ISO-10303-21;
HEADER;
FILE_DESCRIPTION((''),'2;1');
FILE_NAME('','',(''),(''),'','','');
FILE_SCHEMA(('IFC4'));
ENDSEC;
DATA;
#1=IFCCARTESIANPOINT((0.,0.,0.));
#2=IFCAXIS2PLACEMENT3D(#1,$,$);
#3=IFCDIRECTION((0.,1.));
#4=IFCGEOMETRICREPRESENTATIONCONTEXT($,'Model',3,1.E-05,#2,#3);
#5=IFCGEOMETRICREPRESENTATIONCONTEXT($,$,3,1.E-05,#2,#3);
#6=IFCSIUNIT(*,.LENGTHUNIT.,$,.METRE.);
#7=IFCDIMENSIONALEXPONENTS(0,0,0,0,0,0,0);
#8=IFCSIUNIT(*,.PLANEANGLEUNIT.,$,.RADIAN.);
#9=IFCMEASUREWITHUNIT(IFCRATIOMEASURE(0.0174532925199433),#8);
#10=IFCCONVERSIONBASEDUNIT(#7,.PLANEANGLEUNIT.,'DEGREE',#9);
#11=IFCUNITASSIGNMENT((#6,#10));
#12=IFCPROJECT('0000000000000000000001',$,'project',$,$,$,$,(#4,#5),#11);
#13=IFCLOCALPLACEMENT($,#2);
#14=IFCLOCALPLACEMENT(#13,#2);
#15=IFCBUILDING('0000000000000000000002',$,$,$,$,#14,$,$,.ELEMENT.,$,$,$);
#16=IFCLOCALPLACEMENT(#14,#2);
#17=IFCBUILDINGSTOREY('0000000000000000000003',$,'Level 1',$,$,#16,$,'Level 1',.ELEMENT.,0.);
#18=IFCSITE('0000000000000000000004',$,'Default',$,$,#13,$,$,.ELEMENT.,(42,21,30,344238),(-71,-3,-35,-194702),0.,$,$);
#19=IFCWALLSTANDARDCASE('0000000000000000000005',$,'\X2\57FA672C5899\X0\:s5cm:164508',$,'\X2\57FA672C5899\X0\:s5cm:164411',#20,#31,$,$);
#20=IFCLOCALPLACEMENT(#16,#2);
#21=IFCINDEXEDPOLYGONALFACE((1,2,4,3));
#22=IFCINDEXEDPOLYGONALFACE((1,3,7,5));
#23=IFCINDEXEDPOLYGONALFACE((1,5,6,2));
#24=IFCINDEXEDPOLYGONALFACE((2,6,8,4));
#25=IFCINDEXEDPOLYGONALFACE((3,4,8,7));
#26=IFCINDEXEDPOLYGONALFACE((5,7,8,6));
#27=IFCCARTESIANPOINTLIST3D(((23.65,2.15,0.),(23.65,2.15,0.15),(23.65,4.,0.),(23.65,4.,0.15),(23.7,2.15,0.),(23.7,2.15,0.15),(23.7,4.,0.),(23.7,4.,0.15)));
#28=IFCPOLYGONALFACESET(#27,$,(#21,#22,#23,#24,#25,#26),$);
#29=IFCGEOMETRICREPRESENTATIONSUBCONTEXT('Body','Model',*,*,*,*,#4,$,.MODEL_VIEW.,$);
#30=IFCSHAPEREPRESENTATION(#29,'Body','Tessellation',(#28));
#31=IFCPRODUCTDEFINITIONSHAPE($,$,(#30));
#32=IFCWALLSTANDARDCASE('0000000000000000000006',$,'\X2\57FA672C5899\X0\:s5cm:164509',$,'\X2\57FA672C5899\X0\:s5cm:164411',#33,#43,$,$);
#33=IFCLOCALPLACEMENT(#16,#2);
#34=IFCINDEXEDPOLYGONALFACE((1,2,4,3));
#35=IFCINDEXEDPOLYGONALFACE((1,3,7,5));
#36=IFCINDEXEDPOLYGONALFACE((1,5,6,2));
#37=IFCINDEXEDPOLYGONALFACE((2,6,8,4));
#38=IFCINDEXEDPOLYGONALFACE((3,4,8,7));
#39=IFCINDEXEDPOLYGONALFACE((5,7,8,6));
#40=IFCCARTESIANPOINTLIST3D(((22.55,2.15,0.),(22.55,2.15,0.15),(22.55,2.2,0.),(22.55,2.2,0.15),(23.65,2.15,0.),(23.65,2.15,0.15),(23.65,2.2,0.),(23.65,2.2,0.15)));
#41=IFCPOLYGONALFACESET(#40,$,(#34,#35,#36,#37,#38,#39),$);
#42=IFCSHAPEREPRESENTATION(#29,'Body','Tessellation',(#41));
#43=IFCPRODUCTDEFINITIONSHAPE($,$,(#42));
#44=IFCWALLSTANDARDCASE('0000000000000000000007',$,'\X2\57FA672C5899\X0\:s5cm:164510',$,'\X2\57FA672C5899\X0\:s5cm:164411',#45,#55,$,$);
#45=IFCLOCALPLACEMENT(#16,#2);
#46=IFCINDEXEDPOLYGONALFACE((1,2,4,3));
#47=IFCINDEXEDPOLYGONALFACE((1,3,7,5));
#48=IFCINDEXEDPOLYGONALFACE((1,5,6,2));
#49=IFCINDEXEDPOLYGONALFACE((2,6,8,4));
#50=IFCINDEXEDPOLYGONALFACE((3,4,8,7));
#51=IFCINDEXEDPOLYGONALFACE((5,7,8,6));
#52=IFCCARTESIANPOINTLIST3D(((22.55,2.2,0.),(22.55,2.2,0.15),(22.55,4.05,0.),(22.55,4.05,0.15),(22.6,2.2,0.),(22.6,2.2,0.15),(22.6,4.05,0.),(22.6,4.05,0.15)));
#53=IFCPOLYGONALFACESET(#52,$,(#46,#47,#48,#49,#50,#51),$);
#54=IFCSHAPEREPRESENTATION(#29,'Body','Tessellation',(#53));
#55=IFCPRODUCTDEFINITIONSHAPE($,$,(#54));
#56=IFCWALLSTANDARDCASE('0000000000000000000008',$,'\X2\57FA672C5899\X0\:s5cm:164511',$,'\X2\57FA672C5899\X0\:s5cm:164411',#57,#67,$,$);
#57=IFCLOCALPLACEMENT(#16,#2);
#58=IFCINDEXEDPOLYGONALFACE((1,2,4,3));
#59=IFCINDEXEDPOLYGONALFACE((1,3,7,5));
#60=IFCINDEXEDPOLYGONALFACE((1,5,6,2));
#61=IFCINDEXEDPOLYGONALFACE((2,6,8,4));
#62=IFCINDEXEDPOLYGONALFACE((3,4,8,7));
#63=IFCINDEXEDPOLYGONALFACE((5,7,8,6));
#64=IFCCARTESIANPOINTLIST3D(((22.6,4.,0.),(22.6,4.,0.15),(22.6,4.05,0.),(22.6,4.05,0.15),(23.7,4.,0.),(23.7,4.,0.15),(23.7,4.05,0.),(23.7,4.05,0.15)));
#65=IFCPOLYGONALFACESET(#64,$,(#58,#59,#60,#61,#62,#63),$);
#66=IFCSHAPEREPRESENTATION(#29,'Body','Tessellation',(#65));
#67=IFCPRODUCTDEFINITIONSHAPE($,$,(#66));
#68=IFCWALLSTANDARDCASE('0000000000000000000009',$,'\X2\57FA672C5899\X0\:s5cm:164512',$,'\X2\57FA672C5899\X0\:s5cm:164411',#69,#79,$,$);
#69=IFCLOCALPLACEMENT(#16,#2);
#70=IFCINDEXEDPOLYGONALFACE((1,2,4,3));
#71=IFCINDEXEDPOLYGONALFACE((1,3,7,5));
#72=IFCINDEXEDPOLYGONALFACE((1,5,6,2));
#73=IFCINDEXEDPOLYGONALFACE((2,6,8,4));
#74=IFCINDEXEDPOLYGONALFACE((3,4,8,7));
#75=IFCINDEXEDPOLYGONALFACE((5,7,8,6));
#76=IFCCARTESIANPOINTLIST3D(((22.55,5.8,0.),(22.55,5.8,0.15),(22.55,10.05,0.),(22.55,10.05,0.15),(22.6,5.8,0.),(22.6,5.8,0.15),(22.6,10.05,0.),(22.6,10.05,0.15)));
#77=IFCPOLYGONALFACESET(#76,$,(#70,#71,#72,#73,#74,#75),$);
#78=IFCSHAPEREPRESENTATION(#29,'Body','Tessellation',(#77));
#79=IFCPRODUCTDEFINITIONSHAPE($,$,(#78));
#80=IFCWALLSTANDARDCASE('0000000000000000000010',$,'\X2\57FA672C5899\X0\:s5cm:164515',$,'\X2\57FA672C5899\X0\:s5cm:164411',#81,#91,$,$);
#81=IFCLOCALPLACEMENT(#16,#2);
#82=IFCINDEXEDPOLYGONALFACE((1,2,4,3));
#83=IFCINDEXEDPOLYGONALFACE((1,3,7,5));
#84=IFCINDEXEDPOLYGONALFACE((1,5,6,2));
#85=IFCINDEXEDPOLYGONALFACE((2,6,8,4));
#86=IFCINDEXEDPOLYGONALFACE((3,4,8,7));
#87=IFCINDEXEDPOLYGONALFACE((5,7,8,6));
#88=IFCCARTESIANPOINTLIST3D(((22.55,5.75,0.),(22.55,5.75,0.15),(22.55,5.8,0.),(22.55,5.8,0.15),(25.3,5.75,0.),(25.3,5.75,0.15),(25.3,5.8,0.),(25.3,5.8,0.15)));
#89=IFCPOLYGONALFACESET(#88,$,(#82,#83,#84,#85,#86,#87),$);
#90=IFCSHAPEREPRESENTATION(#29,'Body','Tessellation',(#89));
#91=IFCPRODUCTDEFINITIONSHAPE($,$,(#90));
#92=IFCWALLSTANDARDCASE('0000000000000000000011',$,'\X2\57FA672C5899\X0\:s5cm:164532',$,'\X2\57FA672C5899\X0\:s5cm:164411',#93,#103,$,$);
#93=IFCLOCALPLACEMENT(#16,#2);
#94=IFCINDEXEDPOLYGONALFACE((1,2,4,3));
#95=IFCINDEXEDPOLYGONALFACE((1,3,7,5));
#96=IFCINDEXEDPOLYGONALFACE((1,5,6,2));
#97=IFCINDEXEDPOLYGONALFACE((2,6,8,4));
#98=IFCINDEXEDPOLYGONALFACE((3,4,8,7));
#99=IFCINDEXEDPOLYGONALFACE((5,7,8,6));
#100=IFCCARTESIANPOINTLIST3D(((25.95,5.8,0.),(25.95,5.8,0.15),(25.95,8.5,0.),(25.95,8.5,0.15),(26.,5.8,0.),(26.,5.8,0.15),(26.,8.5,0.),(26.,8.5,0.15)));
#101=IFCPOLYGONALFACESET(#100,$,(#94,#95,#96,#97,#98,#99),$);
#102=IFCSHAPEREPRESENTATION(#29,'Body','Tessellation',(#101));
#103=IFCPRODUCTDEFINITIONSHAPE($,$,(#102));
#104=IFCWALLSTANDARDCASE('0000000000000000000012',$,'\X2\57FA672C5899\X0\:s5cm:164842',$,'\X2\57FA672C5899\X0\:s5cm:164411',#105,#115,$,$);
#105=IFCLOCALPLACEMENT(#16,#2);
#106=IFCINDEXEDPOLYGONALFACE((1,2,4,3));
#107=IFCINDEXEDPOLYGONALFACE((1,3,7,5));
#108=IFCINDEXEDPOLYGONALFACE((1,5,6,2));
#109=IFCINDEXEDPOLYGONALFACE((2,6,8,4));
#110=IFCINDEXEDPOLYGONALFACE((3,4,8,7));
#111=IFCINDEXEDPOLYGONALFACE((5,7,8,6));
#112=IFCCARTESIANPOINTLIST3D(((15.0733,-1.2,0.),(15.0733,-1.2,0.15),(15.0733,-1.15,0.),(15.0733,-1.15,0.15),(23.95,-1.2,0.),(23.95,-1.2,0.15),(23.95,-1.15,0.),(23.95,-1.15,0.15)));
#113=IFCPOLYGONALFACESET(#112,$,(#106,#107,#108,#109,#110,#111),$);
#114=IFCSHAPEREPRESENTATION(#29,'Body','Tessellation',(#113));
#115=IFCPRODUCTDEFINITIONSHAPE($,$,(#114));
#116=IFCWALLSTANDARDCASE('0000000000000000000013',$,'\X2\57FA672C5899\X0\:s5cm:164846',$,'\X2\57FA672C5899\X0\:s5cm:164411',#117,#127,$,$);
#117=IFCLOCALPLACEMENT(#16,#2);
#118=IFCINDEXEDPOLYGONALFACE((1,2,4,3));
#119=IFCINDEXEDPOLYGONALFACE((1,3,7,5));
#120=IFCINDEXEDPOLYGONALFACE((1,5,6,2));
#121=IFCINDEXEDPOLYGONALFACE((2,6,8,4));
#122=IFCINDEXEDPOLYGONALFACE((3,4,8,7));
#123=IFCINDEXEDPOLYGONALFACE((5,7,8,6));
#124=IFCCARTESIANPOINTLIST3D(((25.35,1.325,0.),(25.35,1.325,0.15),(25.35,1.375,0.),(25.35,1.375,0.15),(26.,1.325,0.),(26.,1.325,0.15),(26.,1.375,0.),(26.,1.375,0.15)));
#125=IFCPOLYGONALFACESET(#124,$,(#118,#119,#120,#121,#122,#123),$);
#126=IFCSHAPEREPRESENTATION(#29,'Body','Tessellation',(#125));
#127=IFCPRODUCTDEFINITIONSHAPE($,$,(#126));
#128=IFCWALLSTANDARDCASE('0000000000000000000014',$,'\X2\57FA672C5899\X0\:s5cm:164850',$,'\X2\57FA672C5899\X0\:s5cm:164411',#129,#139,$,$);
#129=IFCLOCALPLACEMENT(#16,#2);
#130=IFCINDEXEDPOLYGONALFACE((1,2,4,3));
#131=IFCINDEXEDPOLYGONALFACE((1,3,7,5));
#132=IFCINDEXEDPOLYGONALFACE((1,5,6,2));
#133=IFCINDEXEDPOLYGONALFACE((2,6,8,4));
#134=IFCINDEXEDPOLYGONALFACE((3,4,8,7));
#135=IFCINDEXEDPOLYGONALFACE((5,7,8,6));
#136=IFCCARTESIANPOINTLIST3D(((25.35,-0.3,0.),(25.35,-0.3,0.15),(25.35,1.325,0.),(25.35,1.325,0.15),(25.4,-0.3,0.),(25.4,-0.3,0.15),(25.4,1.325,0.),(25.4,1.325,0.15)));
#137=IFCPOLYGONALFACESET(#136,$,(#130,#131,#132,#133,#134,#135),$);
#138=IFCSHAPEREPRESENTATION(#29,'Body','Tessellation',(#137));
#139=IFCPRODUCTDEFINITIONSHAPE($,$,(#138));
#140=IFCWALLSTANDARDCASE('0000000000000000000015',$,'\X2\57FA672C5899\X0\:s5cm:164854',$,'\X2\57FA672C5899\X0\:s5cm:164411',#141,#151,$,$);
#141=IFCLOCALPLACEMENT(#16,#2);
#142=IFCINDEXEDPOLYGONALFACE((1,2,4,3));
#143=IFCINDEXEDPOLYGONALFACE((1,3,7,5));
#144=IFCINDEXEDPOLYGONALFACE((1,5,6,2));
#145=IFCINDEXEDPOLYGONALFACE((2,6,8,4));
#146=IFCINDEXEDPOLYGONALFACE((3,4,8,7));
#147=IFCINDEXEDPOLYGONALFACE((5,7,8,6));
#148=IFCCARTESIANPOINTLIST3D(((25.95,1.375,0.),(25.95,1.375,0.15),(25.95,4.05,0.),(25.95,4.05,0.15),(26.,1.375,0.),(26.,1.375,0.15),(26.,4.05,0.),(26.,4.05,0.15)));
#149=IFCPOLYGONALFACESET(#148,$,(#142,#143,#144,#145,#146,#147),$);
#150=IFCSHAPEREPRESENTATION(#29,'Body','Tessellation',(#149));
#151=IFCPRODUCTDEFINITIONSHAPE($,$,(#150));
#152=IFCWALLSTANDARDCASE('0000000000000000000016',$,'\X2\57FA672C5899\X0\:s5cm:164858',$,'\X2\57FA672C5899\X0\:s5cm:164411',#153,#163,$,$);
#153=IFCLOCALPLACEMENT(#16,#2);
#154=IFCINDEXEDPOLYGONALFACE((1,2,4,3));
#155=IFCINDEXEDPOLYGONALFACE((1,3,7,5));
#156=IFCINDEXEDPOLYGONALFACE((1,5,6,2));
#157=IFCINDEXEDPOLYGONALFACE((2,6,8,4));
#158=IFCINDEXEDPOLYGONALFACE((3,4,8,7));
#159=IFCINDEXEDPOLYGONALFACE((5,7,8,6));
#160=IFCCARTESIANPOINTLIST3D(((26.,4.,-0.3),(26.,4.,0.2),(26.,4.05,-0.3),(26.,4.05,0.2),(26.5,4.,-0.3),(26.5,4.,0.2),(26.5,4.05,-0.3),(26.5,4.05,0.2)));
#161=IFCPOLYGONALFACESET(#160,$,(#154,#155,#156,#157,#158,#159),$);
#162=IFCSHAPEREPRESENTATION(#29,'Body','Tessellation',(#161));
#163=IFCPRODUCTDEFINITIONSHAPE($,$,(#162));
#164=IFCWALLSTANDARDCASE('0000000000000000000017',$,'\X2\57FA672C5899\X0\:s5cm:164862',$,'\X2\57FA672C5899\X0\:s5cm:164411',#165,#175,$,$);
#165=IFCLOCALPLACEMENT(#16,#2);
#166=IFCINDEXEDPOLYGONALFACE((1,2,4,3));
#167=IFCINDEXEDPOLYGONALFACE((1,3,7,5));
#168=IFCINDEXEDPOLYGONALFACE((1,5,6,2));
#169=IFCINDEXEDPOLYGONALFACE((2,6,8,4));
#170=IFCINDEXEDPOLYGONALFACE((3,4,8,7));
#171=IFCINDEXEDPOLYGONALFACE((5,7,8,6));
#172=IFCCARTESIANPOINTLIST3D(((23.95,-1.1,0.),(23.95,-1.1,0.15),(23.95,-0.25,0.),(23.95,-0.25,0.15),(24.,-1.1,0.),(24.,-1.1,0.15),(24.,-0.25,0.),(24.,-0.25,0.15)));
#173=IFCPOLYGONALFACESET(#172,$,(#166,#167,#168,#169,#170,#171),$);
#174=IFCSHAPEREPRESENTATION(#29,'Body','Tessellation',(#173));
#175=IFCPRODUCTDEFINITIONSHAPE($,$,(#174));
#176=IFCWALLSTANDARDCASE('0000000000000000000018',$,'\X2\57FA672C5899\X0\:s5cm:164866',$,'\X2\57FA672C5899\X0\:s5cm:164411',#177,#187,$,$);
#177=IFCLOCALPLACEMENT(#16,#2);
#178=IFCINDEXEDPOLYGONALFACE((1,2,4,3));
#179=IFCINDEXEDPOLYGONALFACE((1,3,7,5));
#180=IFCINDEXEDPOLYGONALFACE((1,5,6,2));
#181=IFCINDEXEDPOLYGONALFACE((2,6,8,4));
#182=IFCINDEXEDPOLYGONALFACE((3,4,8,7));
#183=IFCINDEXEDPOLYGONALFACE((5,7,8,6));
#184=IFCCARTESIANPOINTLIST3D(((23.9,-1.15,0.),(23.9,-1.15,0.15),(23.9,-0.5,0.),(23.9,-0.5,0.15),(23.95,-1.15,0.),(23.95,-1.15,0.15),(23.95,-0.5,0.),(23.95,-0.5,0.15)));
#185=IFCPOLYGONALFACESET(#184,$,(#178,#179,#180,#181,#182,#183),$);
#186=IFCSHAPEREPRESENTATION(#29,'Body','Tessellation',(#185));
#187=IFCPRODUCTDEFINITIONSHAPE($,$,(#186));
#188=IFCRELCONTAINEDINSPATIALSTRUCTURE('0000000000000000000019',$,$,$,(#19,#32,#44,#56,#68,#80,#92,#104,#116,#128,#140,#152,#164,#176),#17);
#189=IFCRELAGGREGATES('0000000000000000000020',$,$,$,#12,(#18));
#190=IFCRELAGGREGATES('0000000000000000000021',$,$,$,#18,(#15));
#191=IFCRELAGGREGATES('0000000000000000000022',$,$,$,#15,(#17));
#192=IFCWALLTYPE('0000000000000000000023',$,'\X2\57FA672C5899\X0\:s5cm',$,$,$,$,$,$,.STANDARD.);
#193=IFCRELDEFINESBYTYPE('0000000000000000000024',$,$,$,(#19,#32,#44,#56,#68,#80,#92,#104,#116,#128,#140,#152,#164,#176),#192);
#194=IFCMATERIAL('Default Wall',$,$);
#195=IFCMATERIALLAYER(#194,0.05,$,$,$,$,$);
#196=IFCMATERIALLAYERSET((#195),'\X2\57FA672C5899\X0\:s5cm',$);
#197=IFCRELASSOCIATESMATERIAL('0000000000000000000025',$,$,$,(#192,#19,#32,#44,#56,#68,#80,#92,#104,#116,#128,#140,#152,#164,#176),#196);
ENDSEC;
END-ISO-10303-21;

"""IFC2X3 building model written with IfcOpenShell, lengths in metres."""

from ifc_helpers import new_model, entity, si_unit, converted_unit, direction, frame, frame_2d, origin, place, context, subcontext, project, spatial, rectangle, extrude, material, layer, layer_set, layer_usage, type_object, element, save


model = new_model("IFC2X3")

# Units and contexts
model_context = context("Model", 3, precision=1e-05, world=origin(), true_north=direction((0.0, 1.0)))
context_of_model = context(None, 3, precision=1e-05, world=origin(), true_north=direction((0.0, 1.0)))
body_context = subcontext(model_context, "Body", "Model", "MODEL_VIEW")
ifc_project = project(units=[si_unit("LENGTHUNIT", "METRE"), converted_unit("PLANEANGLEUNIT", "DEGREE", entity("IfcRatioMeasure", 0.0174532925199433), si_unit("PLANEANGLEUNIT", "RADIAN"), dimensions=[0, 0, 0, 0, 0, 0, 0])], contexts=[model_context, context_of_model])

# Site, building, storey
site_placement = place(None, origin())
site = spatial("IfcSite", under=ifc_project, at=site_placement, Name="Default", CompositionType="ELEMENT", RefLatitude=(42, 21, 30, 344238), RefLongitude=(-71, -3, -35, -194702), RefElevation=0.0)
building_placement = place(site_placement, origin())
building = spatial("IfcBuilding", under=site, at=building_placement, CompositionType="ELEMENT")
storey_placement = place(building_placement, origin())
storey = spatial("IfcBuildingStorey", under=building, at=storey_placement, Name="Level 1", LongName="Level 1", CompositionType="ELEMENT", Elevation=0.0)

# Walls
ifc_material = material(Name="Default Wall")
ifc_layer = layer(ifc_material, 0.05)
ifc_layer_set = layer_set([ifc_layer], Name="基本墙:s5cm")
ifc_layer_usage_1 = layer_usage(ifc_layer_set, "AXIS2", "NEGATIVE", 0.025)
wall_type = type_object("IfcWallType", Name="基本墙:s5cm", PredefinedType="STANDARD", material=ifc_layer_set)
wall_1_placement = place(storey_placement, frame((23.675, 4.0, 0.0), z_axis=(0.0, 0.0, 1.0), x_axis=(0.0, -1.0, 0.0)))
element("IfcWallStandardCase", 1, at=wall_1_placement, inside=storey, type_object=wall_type, material=ifc_layer_usage_1, Name="基本墙:s5cm:164508", ObjectType="基本墙:s5cm:164411", context=body_context, shape_type="SweptSolid", body=[
    extrude(rectangle(XDim=1.85, YDim=0.05, at=frame_2d((0.925, 0.0), x_axis=(-1.0, 0.0))), origin(), (0.0, 0.0, 1.0), 0.15),
])
ifc_layer_usage_2 = layer_usage(ifc_layer_set, "AXIS2", "NEGATIVE", 0.025)
wall_2_placement = place(storey_placement, frame((23.65, 2.175, 0.0), z_axis=(0.0, 0.0, 1.0), x_axis=(-1.0, 0.0, 0.0)))
element("IfcWallStandardCase", 2, at=wall_2_placement, inside=storey, type_object=wall_type, material=ifc_layer_usage_2, Name="基本墙:s5cm:164509", ObjectType="基本墙:s5cm:164411", context=body_context, shape_type="SweptSolid", body=[
    extrude(rectangle(XDim=1.1, YDim=0.05, at=frame_2d((0.55, 0.0), x_axis=(-1.0, 0.0))), origin(), (0.0, 0.0, 1.0), 0.15),
])
ifc_layer_usage_3 = layer_usage(ifc_layer_set, "AXIS2", "NEGATIVE", 0.025)
wall_3_placement = place(storey_placement, frame((22.575, 2.2, 0.0), z_axis=(0.0, 0.0, 1.0), x_axis=(0.0, 1.0, 0.0)))
element("IfcWallStandardCase", 3, at=wall_3_placement, inside=storey, type_object=wall_type, material=ifc_layer_usage_3, Name="基本墙:s5cm:164510", ObjectType="基本墙:s5cm:164411", context=body_context, shape_type="SweptSolid", body=[
    extrude(rectangle(XDim=1.85, YDim=0.05, at=frame_2d((0.925, 0.0), x_axis=(-1.0, 0.0))), origin(), (0.0, 0.0, 1.0), 0.15),
])
ifc_layer_usage_4 = layer_usage(ifc_layer_set, "AXIS2", "NEGATIVE", 0.025)
wall_4_placement = place(storey_placement, frame((22.6, 4.025, 0.0)))
element("IfcWallStandardCase", 4, at=wall_4_placement, inside=storey, type_object=wall_type, material=ifc_layer_usage_4, Name="基本墙:s5cm:164511", ObjectType="基本墙:s5cm:164411", context=body_context, shape_type="SweptSolid", body=[
    extrude(rectangle(XDim=1.1, YDim=0.05, at=frame_2d((0.55, 0.0), x_axis=(-1.0, 0.0))), origin(), (0.0, 0.0, 1.0), 0.15),
])
ifc_layer_usage_5 = layer_usage(ifc_layer_set, "AXIS2", "NEGATIVE", 0.025)
wall_5_placement = place(storey_placement, frame((22.575, 5.8, 0.0), z_axis=(0.0, 0.0, 1.0), x_axis=(0.0, 1.0, 0.0)))
element("IfcWallStandardCase", 5, at=wall_5_placement, inside=storey, type_object=wall_type, material=ifc_layer_usage_5, Name="基本墙:s5cm:164512", ObjectType="基本墙:s5cm:164411", context=body_context, shape_type="SweptSolid", body=[
    extrude(rectangle(XDim=4.25, YDim=0.05, at=frame_2d((2.125, 0.0), x_axis=(-1.0, 0.0))), origin(), (0.0, 0.0, 1.0), 0.15),
])
ifc_layer_usage_6 = layer_usage(ifc_layer_set, "AXIS2", "NEGATIVE", 0.025)
wall_6_placement = place(storey_placement, frame((25.3, 5.775, 0.0), z_axis=(0.0, 0.0, 1.0), x_axis=(-1.0, 0.0, 0.0)))
element("IfcWallStandardCase", 6, at=wall_6_placement, inside=storey, type_object=wall_type, material=ifc_layer_usage_6, Name="基本墙:s5cm:164515", ObjectType="基本墙:s5cm:164411", context=body_context, shape_type="SweptSolid", body=[
    extrude(rectangle(XDim=2.75, YDim=0.05, at=frame_2d((1.375, 0.0), x_axis=(-1.0, 0.0))), origin(), (0.0, 0.0, 1.0), 0.15),
])
ifc_layer_usage_7 = layer_usage(ifc_layer_set, "AXIS2", "NEGATIVE", 0.025)
wall_7_placement = place(storey_placement, frame((25.975, 5.8, 0.0), z_axis=(0.0, 0.0, 1.0), x_axis=(0.0, 1.0, 0.0)))
element("IfcWallStandardCase", 7, at=wall_7_placement, inside=storey, type_object=wall_type, material=ifc_layer_usage_7, Name="基本墙:s5cm:164532", ObjectType="基本墙:s5cm:164411", context=body_context, shape_type="SweptSolid", body=[
    extrude(rectangle(XDim=2.7, YDim=0.05, at=frame_2d((1.35, 0.0), x_axis=(-1.0, 0.0))), origin(), (0.0, 0.0, 1.0), 0.15),
])
ifc_layer_usage_8 = layer_usage(ifc_layer_set, "AXIS2", "NEGATIVE", 0.025)
wall_8_placement = place(storey_placement, frame((23.95, -1.175, 0.0), z_axis=(0.0, 0.0, 1.0), x_axis=(-1.0, 0.0, 0.0)))
element("IfcWallStandardCase", 8, at=wall_8_placement, inside=storey, type_object=wall_type, material=ifc_layer_usage_8, Name="基本墙:s5cm:164842", ObjectType="基本墙:s5cm:164411", context=body_context, shape_type="SweptSolid", body=[
    extrude(rectangle(XDim=8.8767, YDim=0.05, at=frame_2d((4.4384, 0.0), x_axis=(-1.0, 0.0))), origin(), (0.0, 0.0, 1.0), 0.15),
])
ifc_layer_usage_9 = layer_usage(ifc_layer_set, "AXIS2", "NEGATIVE", 0.025)
wall_9_placement = place(storey_placement, frame((25.35, 1.35, 0.0)))
element("IfcWallStandardCase", 9, at=wall_9_placement, inside=storey, type_object=wall_type, material=ifc_layer_usage_9, Name="基本墙:s5cm:164846", ObjectType="基本墙:s5cm:164411", context=body_context, shape_type="SweptSolid", body=[
    extrude(rectangle(XDim=0.65, YDim=0.05, at=frame_2d((0.325, 0.0), x_axis=(-1.0, 0.0))), origin(), (0.0, 0.0, 1.0), 0.15),
])
ifc_layer_usage_10 = layer_usage(ifc_layer_set, "AXIS2", "NEGATIVE", 0.025)
wall_10_placement = place(storey_placement, frame((25.375, 1.325, 0.0), z_axis=(0.0, 0.0, 1.0), x_axis=(0.0, -1.0, 0.0)))
element("IfcWallStandardCase", 10, at=wall_10_placement, inside=storey, type_object=wall_type, material=ifc_layer_usage_10, Name="基本墙:s5cm:164850", ObjectType="基本墙:s5cm:164411", context=body_context, shape_type="SweptSolid", body=[
    extrude(rectangle(XDim=1.625, YDim=0.05, at=frame_2d((0.8125, 0.0), x_axis=(-1.0, 0.0))), origin(), (0.0, 0.0, 1.0), 0.15),
])
ifc_layer_usage_11 = layer_usage(ifc_layer_set, "AXIS2", "NEGATIVE", 0.025)
wall_11_placement = place(storey_placement, frame((25.975, 1.375, 0.0), z_axis=(0.0, 0.0, 1.0), x_axis=(0.0, 1.0, 0.0)))
element("IfcWallStandardCase", 11, at=wall_11_placement, inside=storey, type_object=wall_type, material=ifc_layer_usage_11, Name="基本墙:s5cm:164854", ObjectType="基本墙:s5cm:164411", context=body_context, shape_type="SweptSolid", body=[
    extrude(rectangle(XDim=2.675, YDim=0.05, at=frame_2d((1.3375, 0.0), x_axis=(-1.0, 0.0))), origin(), (0.0, 0.0, 1.0), 0.15),
])
ifc_layer_usage_12 = layer_usage(ifc_layer_set, "AXIS2", "NEGATIVE", 0.025)
wall_12_placement = place(storey_placement, frame((26.0, 4.025, -0.3)))
element("IfcWallStandardCase", 12, at=wall_12_placement, inside=storey, type_object=wall_type, material=ifc_layer_usage_12, Name="基本墙:s5cm:164858", ObjectType="基本墙:s5cm:164411", context=body_context, shape_type="SweptSolid", body=[
    extrude(rectangle(XDim=0.5, YDim=0.05, at=frame_2d((0.25, 0.0), x_axis=(-1.0, 0.0))), origin(), (0.0, 0.0, 1.0), 0.5),
])
ifc_layer_usage_13 = layer_usage(ifc_layer_set, "AXIS2", "NEGATIVE", 0.025)
wall_13_placement = place(storey_placement, frame((23.975, -1.1, 0.0), z_axis=(0.0, 0.0, 1.0), x_axis=(0.0, 1.0, 0.0)))
element("IfcWallStandardCase", 13, at=wall_13_placement, inside=storey, type_object=wall_type, material=ifc_layer_usage_13, Name="基本墙:s5cm:164862", ObjectType="基本墙:s5cm:164411", context=body_context, shape_type="SweptSolid", body=[
    extrude(rectangle(XDim=0.85, YDim=0.05, at=frame_2d((0.425, 0.0), x_axis=(-1.0, 0.0))), origin(), (0.0, 0.0, 1.0), 0.15),
])
ifc_layer_usage_14 = layer_usage(ifc_layer_set, "AXIS2", "NEGATIVE", 0.025)
wall_14_placement = place(storey_placement, frame((23.925, -0.5, 0.0), z_axis=(0.0, 0.0, 1.0), x_axis=(0.0, -1.0, 0.0)))
element("IfcWallStandardCase", 14, at=wall_14_placement, inside=storey, type_object=wall_type, material=ifc_layer_usage_14, Name="基本墙:s5cm:164866", ObjectType="基本墙:s5cm:164411", context=body_context, shape_type="SweptSolid", body=[
    extrude(rectangle(XDim=0.65, YDim=0.05, at=frame_2d((0.325, 0.0), x_axis=(-1.0, 0.0))), origin(), (0.0, 0.0, 1.0), 0.15),
])

save(model, "model.ifc")
